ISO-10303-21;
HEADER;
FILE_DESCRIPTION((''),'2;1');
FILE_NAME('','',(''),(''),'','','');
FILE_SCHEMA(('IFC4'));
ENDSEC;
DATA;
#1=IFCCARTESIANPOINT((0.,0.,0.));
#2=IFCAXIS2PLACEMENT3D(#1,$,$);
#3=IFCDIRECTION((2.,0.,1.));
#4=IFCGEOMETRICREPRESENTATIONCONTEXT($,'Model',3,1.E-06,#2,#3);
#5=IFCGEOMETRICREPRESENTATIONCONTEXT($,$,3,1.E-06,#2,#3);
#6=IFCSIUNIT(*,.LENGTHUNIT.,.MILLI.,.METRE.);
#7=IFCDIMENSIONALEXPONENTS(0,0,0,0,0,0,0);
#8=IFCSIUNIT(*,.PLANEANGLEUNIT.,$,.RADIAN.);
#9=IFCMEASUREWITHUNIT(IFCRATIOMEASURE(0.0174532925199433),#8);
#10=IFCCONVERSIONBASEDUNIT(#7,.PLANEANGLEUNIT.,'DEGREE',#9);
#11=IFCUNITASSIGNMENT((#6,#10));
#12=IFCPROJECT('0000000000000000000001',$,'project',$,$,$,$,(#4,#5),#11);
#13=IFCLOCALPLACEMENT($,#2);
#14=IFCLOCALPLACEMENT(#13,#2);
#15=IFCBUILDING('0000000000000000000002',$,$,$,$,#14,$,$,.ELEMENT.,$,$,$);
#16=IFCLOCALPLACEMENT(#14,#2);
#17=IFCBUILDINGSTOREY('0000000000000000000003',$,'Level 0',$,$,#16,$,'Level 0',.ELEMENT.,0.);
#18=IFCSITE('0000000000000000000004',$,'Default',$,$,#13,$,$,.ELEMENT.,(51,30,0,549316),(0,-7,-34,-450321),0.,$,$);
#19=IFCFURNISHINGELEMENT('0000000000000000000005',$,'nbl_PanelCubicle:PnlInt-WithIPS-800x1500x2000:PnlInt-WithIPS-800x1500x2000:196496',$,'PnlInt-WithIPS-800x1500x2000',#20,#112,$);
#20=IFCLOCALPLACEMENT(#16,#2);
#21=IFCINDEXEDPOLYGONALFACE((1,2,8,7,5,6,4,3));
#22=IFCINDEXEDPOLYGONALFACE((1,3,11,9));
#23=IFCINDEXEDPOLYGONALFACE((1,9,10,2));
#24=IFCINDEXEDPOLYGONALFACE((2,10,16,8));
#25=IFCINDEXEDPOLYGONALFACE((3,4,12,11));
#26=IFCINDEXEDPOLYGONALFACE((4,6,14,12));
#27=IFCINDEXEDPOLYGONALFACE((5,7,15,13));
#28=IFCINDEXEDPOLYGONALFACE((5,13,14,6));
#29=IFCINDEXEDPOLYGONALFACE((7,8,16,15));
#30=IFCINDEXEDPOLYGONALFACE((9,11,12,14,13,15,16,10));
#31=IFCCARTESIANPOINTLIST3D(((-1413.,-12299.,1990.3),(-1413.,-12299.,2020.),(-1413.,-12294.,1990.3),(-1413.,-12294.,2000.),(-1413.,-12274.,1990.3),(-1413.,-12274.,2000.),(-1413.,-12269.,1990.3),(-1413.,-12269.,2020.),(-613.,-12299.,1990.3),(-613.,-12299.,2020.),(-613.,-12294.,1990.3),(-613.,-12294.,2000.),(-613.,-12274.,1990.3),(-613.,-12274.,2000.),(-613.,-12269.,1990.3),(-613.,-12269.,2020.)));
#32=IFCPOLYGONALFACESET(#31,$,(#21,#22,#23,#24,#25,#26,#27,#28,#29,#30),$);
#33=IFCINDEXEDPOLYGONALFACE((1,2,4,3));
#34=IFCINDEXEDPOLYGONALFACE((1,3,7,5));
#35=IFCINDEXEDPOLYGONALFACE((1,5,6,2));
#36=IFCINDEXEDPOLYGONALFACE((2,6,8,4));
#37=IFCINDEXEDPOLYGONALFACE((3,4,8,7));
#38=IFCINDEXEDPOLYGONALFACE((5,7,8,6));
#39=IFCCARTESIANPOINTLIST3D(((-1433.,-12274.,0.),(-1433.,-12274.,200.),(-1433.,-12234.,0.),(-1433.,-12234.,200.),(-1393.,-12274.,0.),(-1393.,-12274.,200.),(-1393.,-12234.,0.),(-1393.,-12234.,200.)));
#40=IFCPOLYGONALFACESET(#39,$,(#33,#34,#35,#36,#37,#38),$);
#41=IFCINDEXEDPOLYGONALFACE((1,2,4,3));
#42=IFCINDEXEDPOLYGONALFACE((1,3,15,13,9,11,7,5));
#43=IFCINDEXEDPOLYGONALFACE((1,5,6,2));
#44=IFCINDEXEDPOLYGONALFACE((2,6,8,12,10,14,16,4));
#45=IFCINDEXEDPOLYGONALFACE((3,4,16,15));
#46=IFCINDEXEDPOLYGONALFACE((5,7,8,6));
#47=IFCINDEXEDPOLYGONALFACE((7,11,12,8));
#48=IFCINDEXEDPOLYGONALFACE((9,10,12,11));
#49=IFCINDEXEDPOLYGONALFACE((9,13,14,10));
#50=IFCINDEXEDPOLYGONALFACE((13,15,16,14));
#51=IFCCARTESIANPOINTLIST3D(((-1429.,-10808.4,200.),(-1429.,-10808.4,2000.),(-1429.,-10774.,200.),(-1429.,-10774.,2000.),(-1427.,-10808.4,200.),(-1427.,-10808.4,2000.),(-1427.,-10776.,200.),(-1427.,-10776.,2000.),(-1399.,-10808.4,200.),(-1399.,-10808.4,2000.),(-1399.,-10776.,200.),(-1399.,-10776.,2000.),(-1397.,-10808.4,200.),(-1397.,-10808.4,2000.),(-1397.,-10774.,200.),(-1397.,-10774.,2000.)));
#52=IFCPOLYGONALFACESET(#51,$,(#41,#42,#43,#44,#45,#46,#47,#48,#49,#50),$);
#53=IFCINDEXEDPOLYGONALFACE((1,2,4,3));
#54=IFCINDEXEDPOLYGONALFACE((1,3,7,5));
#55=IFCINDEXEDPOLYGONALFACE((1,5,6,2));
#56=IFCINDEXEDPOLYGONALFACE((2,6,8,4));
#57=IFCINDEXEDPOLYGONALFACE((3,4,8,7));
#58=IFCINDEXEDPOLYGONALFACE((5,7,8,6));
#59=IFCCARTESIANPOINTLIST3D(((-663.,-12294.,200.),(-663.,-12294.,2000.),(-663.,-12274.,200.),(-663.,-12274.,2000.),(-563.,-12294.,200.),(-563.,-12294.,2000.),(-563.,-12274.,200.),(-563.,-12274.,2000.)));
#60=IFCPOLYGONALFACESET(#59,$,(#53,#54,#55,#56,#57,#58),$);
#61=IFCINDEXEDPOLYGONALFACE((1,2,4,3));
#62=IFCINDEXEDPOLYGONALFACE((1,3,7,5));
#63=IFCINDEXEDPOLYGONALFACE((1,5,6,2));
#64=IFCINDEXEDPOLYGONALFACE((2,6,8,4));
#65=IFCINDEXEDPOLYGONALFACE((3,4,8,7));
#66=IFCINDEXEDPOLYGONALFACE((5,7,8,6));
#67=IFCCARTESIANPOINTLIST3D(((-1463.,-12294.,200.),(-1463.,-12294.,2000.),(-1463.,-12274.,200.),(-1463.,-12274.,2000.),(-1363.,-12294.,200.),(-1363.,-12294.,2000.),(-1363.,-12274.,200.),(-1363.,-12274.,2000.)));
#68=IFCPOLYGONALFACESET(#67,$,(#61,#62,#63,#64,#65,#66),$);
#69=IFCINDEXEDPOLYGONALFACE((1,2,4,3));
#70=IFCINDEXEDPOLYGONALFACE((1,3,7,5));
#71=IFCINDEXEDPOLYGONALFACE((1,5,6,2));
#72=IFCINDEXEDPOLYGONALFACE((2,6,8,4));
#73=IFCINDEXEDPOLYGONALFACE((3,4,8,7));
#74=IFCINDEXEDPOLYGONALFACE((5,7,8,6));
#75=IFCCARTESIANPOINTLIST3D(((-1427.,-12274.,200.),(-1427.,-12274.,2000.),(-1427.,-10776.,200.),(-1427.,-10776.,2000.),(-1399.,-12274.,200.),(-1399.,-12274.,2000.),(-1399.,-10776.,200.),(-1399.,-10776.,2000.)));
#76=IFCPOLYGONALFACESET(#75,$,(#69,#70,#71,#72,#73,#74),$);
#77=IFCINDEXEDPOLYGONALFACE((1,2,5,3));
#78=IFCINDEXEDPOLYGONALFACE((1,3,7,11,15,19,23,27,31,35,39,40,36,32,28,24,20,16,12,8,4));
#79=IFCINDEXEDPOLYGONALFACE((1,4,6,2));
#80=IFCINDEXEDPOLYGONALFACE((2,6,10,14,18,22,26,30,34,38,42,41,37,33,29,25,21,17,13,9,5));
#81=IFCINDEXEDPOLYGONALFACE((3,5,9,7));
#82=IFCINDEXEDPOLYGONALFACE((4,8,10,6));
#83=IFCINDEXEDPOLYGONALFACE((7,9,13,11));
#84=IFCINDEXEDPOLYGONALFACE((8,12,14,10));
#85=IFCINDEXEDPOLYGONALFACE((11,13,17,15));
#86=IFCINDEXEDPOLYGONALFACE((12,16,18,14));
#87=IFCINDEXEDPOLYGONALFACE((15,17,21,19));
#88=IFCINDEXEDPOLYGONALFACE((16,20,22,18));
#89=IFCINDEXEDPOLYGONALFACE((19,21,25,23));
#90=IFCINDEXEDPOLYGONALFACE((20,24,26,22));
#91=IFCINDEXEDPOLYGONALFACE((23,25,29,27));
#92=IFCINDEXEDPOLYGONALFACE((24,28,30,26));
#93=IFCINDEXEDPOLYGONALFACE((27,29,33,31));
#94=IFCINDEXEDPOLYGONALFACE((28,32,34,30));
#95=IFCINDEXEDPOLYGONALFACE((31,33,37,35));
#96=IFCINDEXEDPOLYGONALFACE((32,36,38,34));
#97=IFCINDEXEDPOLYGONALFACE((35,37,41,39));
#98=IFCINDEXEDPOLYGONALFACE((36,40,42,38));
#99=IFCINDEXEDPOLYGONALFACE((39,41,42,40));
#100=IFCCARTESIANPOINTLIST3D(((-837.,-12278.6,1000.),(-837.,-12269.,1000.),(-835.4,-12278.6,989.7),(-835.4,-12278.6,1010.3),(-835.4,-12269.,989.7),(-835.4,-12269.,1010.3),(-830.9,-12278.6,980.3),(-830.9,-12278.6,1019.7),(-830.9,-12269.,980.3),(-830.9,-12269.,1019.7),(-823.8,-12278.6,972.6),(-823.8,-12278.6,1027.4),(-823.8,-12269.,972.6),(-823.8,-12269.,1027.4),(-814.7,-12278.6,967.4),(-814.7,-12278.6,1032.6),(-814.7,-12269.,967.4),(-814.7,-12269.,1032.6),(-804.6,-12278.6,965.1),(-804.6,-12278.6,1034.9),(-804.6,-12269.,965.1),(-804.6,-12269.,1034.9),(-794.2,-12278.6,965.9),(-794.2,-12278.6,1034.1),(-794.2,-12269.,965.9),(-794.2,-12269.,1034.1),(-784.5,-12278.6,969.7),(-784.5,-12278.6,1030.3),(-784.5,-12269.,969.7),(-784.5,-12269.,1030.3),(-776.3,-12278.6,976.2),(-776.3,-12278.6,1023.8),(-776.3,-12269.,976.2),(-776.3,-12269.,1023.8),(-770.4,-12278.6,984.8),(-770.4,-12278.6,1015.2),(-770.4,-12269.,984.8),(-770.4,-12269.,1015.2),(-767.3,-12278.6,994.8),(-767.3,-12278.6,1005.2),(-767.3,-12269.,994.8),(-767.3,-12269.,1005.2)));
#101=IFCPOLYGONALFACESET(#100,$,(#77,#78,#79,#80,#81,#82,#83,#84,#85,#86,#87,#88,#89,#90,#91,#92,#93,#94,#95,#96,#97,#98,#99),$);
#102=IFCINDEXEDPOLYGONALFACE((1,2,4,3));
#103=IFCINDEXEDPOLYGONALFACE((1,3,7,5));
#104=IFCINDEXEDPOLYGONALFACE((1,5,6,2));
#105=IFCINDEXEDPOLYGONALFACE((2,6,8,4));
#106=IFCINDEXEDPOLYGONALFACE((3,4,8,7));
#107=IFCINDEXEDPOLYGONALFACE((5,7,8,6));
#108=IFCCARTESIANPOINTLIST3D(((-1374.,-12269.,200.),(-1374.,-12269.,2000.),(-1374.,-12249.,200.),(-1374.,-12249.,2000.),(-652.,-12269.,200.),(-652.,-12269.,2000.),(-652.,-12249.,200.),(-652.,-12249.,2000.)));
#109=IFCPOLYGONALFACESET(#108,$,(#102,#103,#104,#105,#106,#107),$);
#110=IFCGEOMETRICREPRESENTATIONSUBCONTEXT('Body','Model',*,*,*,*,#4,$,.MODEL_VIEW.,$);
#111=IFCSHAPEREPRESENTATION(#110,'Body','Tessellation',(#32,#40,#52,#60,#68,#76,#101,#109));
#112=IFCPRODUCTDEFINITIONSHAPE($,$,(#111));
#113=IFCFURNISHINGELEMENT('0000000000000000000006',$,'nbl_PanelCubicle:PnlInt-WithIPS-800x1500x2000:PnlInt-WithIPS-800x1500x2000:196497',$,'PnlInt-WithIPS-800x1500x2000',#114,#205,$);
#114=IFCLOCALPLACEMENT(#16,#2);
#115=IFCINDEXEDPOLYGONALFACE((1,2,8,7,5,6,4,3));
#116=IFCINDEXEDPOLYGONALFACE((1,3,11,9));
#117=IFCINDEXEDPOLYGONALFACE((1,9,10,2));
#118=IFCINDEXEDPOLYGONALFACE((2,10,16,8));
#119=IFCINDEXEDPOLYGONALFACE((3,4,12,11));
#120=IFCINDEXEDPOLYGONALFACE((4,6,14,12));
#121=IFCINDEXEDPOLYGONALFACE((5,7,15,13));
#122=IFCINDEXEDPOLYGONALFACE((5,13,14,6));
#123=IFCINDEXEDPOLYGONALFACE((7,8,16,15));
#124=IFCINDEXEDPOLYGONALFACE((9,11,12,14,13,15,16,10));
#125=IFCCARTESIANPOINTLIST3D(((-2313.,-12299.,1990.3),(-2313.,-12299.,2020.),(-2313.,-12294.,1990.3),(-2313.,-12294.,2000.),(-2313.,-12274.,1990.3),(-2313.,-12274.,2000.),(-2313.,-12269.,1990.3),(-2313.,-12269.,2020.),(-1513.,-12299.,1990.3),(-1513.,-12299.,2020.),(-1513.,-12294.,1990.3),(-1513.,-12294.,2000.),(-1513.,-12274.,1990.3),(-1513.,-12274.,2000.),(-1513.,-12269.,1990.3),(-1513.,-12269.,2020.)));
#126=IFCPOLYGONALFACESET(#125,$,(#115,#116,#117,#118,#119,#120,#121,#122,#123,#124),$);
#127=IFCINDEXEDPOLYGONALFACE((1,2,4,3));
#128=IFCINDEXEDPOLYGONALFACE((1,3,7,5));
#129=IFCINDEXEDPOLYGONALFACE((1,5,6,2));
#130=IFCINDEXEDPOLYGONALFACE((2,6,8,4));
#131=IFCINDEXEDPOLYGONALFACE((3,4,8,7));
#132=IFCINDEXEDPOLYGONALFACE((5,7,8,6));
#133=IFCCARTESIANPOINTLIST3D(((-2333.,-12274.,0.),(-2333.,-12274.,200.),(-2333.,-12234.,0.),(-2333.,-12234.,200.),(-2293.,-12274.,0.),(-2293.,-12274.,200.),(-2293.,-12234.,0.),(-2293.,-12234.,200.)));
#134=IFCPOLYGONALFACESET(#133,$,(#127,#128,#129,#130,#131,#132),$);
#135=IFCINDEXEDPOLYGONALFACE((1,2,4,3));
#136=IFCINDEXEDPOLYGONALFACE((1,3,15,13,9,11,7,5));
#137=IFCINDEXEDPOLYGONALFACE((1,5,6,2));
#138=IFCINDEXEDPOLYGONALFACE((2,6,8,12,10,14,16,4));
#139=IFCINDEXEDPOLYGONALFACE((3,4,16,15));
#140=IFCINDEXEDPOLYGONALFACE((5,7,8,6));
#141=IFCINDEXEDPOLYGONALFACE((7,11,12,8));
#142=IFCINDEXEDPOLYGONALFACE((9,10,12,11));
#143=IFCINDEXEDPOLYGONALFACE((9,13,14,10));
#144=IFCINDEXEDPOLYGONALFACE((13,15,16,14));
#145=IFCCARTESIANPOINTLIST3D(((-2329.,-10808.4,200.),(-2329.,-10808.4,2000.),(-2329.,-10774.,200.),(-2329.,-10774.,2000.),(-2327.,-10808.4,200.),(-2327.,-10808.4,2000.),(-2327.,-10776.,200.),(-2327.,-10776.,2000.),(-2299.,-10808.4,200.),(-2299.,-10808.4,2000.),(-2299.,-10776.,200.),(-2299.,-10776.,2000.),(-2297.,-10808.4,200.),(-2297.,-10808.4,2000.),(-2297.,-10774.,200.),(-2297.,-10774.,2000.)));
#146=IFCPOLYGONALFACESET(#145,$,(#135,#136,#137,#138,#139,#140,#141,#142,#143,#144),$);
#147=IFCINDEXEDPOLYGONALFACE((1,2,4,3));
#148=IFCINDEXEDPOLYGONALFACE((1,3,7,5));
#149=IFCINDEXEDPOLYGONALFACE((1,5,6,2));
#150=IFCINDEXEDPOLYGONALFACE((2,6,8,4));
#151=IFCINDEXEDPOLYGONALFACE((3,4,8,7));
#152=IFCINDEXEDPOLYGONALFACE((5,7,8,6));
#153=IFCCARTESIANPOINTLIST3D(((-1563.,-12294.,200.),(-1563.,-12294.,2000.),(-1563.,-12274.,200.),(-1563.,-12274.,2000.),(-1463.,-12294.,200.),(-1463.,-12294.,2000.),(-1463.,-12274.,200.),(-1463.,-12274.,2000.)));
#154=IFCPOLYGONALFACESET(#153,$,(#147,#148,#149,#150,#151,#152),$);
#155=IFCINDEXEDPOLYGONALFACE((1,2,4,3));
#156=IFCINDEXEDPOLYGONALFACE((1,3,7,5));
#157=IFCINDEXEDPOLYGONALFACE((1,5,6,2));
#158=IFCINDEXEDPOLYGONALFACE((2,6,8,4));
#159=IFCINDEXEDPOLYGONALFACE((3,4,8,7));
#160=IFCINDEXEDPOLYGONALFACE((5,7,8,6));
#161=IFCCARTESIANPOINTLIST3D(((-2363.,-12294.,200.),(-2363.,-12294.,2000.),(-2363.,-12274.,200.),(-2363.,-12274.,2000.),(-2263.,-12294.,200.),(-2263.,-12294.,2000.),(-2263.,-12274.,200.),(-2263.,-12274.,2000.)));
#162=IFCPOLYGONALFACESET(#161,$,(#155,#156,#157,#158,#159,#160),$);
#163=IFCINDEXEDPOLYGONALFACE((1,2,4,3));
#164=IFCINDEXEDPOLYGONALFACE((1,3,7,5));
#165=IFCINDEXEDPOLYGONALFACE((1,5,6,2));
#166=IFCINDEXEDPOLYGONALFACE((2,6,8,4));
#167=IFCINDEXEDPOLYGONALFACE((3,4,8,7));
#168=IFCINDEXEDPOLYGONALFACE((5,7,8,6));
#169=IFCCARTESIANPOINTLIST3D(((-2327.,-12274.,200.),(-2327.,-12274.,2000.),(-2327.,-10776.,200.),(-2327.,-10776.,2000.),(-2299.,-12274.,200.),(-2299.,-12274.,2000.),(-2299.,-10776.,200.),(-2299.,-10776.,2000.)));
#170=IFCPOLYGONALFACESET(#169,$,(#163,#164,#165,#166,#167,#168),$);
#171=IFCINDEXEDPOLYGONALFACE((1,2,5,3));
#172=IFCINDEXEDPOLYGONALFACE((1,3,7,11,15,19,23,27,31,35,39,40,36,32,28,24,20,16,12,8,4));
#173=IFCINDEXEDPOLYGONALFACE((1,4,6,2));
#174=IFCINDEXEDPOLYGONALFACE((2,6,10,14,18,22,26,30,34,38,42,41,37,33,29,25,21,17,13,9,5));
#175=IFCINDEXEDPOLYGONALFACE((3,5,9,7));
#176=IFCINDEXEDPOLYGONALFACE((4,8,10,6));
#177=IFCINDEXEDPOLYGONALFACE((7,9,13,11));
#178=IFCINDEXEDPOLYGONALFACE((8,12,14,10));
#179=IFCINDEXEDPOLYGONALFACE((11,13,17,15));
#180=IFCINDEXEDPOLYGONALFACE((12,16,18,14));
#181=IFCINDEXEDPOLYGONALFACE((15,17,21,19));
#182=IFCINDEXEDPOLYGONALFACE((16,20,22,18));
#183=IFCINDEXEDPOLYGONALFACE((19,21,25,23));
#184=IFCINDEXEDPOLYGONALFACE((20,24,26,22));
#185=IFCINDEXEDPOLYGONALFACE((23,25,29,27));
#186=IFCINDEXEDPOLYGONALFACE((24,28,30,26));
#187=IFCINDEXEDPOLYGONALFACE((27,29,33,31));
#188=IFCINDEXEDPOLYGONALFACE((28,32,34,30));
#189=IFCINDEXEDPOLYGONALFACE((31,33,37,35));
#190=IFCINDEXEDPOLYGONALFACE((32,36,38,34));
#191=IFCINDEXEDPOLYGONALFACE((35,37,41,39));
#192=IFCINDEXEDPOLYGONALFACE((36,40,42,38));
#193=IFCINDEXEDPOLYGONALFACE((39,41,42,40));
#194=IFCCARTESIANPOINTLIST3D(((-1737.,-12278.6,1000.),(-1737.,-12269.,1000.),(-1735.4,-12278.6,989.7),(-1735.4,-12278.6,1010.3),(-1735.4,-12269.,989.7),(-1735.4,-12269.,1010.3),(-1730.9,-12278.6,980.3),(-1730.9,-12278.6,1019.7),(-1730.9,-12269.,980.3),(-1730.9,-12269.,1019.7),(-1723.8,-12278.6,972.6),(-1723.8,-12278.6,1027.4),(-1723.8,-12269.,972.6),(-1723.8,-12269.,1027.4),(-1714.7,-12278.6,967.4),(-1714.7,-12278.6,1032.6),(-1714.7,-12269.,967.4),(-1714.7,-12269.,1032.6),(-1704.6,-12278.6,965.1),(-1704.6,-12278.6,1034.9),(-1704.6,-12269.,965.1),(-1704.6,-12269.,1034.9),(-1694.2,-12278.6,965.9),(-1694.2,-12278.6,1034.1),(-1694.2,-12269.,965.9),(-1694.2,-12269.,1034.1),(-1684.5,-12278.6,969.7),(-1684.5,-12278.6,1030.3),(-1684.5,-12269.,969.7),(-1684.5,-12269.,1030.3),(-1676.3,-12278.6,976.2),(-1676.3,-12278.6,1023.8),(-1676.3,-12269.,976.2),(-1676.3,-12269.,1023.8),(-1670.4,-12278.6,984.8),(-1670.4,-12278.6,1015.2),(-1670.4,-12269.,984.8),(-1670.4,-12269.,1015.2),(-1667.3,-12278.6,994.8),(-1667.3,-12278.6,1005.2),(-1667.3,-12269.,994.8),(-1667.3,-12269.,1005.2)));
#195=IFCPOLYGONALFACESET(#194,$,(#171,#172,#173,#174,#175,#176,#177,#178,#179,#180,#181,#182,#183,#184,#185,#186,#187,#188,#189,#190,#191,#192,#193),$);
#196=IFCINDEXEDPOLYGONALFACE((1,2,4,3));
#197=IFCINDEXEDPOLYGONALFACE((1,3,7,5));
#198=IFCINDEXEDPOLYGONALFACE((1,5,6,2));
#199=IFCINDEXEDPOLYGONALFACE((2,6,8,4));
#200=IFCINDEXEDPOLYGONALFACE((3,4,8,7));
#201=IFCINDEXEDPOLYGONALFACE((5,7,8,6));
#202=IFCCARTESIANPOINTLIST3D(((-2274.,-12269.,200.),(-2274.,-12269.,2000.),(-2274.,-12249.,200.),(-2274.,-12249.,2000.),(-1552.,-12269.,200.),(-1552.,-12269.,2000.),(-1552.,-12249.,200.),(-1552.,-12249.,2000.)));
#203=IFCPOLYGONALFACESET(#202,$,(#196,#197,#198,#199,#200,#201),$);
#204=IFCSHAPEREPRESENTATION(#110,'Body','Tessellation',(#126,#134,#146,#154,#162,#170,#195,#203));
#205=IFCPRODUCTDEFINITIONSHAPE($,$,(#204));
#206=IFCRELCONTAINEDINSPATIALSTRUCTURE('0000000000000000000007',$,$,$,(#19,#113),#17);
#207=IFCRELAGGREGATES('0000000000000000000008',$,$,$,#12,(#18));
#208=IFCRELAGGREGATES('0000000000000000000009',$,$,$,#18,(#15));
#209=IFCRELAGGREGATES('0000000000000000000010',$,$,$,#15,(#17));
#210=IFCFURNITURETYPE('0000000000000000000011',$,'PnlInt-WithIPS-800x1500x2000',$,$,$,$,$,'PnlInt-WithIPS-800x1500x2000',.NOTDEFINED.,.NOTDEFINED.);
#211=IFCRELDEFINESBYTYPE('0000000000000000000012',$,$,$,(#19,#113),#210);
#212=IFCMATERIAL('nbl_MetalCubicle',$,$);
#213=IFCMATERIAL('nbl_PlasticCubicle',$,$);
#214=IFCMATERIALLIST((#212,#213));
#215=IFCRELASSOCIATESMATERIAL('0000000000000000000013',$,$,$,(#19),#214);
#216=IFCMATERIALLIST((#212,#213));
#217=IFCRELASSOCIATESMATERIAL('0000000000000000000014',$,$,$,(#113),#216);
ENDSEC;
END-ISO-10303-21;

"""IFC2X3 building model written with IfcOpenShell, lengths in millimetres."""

from ifc_helpers import new_model, entity, si_unit, converted_unit, direction, frame, frame_2d, origin, origin_2d_with_axis, place, context, subcontext, project, spatial, polyline, rectangle, circle, outline, extrude, source, transform, mapped, material, material_list, type_object, type_shapes, element, save


model = new_model("IFC2X3")

# Units and contexts
model_context = context("Model", 3, precision=1e-06, world=origin(), true_north=direction((2.0, 0.0, 1.0)))
context_of_model = context(None, 3, precision=1e-06, world=origin(), true_north=direction((2.0, 0.0, 1.0)))
body_context = subcontext(model_context, "Body", "Model", "MODEL_VIEW")
ifc_project = project(units=[si_unit("LENGTHUNIT", "METRE", prefix="MILLI"), converted_unit("PLANEANGLEUNIT", "DEGREE", entity("IfcRatioMeasure", 0.0174532925199433), si_unit("PLANEANGLEUNIT", "RADIAN"), dimensions=[0, 0, 0, 0, 0, 0, 0])], contexts=[model_context, context_of_model])

# Site, building, storey
site_placement = place(None, origin())
site = spatial("IfcSite", under=ifc_project, at=site_placement, Name="Default", CompositionType="ELEMENT", RefLatitude=(51, 30, 0, 549316), RefLongitude=(0, -7, -34, -450321), RefElevation=0.0)
building_placement = place(site_placement, origin())
building = spatial("IfcBuilding", under=site, at=building_placement, CompositionType="ELEMENT")
storey_placement = place(building_placement, origin())
storey = spatial("IfcBuildingStorey", under=building, at=storey_placement, Name="Level 0", LongName="Level 0", CompositionType="ELEMENT", Elevation=0.0)

# Furnishing elements
ifc_material_1 = material(Name="nbl_MetalCubicle")
ifc_material_2 = material(Name="nbl_PlasticCubicle")
ifc_material_list_1 = material_list([ifc_material_1, ifc_material_2])
furniture_type_1 = type_object("IfcFurnitureType", Name="PnlInt-WithIPS-800x1500x2000", ElementType="PnlInt-WithIPS-800x1500x2000", AssemblyPlace="NOTDEFINED")
shared_shape_1 = source(origin(), body_context, "Body", "SweptSolid", [
    extrude(outline(polyline([(-19.8, -15.0), (9.8, -15.0), (9.8, -10.0), (0.2, -10.0), (0.2, 10.0), (9.8, 10.0), (9.8, 15.0), (-19.8, 15.0), (-19.8, -15.0)])), frame((-275.0, 1560.0, 2000.2), z_axis=(1.0, 0.0, 0.0), x_axis=(0.0, 0.0, -1.0)), (0.0, 0.0, 1.0), 800.0),
    extrude(rectangle(XDim=40.0, YDim=40.0, at=frame_2d((0.0, 0.0), x_axis=(1.0, 0.0))), frame((525.0, 1530.0, 0.0), z_axis=(0.0, 0.0, 1.0), x_axis=(0.0, 1.0, 0.0)), (0.0, 0.0, 1.0), 200.0),
    extrude(outline(polyline([(14.0, -16.7), (16.0, -16.7), (16.0, 17.7), (-16.0, 17.7), (-16.0, -16.7), (-14.0, -16.7), (-14.0, 15.7), (14.0, 15.7), (14.0, -16.7)])), frame((525.0, 67.7, 200.0), z_axis=(0.0, 0.0, 1.0), x_axis=(-1.0, 0.0, 0.0)), (0.0, 0.0, 1.0), 1800.0),
    extrude(rectangle(XDim=100.0, YDim=20.0, at=frame_2d((0.0, 0.0), x_axis=(1.0, 0.0))), frame((-275.0, 1560.0, 200.0), z_axis=(0.0, 0.0, 1.0), x_axis=(-1.0, 0.0, 0.0)), (0.0, 0.0, 1.0), 1800.0),
    extrude(rectangle(XDim=100.0, YDim=20.0, at=frame_2d((0.0, 0.0), x_axis=(1.0, 0.0))), frame((525.0, 1560.0, 200.0), z_axis=(0.0, 0.0, 1.0), x_axis=(-1.0, 0.0, 0.0)), (0.0, 0.0, 1.0), 1800.0),
    extrude(rectangle(XDim=28.0, YDim=1498.0, at=frame_2d((0.0, 0.0), x_axis=(1.0, 0.0))), frame((525.0, 801.0, 200.0), z_axis=(0.0, 0.0, 1.0), x_axis=(-1.0, 0.0, 0.0)), (0.0, 0.0, 1.0), 1800.0),
    extrude(circle(Radius=35.0, at=frame_2d((0.0, 0.0), x_axis=(1.0, 0.0))), frame((-86.0, 1545.0, 1000.0), z_axis=(0.0, 1.0, 0.0), x_axis=(1.0, 0.0, 0.0)), (0.0, 0.0, 1.0), 9.7),
    extrude(rectangle(XDim=722.0, YDim=20.0, at=origin_2d_with_axis()), frame((125.0, 1535.0, 200.0), z_axis=(0.0, 0.0, 1.0), x_axis=(-1.0, 0.0, 0.0)), (0.0, 0.0, 1.0), 1800.0),
])
type_shapes(furniture_type_1, [shared_shape_1])
furnishing_1_placement = place(storey_placement, frame((-888.0, -10724.0, 0.0), z_axis=(0.0, 0.0, 1.0), x_axis=(-1.0, 0.0, 0.0)))
element("IfcFurnishingElement", 1, at=furnishing_1_placement, inside=storey, type_object=furniture_type_1, material=ifc_material_list_1, Name="nbl_PanelCubicle:PnlInt-WithIPS-800x1500x2000:PnlInt-WithIPS-800x1500x2000:196496", ObjectType="PnlInt-WithIPS-800x1500x2000", context=body_context, shape_type="MappedRepresentation", body=[
    mapped(shared_shape_1, transform((0.0, 0.0, 0.0), scale=1.0)),
])
ifc_material_list_2 = material_list([ifc_material_1, ifc_material_2])
furnishing_2_placement = place(storey_placement, frame((-1788.0, -10724.0, 0.0), z_axis=(0.0, 0.0, 1.0), x_axis=(-1.0, 0.0, 0.0)))
element("IfcFurnishingElement", 2, at=furnishing_2_placement, inside=storey, type_object=furniture_type_1, material=ifc_material_list_2, Name="nbl_PanelCubicle:PnlInt-WithIPS-800x1500x2000:PnlInt-WithIPS-800x1500x2000:196497", ObjectType="PnlInt-WithIPS-800x1500x2000", context=body_context, shape_type="MappedRepresentation", body=[
    mapped(shared_shape_1, transform((0.0, 0.0, 0.0), scale=1.0)),
])

save(model, "model.ifc")
